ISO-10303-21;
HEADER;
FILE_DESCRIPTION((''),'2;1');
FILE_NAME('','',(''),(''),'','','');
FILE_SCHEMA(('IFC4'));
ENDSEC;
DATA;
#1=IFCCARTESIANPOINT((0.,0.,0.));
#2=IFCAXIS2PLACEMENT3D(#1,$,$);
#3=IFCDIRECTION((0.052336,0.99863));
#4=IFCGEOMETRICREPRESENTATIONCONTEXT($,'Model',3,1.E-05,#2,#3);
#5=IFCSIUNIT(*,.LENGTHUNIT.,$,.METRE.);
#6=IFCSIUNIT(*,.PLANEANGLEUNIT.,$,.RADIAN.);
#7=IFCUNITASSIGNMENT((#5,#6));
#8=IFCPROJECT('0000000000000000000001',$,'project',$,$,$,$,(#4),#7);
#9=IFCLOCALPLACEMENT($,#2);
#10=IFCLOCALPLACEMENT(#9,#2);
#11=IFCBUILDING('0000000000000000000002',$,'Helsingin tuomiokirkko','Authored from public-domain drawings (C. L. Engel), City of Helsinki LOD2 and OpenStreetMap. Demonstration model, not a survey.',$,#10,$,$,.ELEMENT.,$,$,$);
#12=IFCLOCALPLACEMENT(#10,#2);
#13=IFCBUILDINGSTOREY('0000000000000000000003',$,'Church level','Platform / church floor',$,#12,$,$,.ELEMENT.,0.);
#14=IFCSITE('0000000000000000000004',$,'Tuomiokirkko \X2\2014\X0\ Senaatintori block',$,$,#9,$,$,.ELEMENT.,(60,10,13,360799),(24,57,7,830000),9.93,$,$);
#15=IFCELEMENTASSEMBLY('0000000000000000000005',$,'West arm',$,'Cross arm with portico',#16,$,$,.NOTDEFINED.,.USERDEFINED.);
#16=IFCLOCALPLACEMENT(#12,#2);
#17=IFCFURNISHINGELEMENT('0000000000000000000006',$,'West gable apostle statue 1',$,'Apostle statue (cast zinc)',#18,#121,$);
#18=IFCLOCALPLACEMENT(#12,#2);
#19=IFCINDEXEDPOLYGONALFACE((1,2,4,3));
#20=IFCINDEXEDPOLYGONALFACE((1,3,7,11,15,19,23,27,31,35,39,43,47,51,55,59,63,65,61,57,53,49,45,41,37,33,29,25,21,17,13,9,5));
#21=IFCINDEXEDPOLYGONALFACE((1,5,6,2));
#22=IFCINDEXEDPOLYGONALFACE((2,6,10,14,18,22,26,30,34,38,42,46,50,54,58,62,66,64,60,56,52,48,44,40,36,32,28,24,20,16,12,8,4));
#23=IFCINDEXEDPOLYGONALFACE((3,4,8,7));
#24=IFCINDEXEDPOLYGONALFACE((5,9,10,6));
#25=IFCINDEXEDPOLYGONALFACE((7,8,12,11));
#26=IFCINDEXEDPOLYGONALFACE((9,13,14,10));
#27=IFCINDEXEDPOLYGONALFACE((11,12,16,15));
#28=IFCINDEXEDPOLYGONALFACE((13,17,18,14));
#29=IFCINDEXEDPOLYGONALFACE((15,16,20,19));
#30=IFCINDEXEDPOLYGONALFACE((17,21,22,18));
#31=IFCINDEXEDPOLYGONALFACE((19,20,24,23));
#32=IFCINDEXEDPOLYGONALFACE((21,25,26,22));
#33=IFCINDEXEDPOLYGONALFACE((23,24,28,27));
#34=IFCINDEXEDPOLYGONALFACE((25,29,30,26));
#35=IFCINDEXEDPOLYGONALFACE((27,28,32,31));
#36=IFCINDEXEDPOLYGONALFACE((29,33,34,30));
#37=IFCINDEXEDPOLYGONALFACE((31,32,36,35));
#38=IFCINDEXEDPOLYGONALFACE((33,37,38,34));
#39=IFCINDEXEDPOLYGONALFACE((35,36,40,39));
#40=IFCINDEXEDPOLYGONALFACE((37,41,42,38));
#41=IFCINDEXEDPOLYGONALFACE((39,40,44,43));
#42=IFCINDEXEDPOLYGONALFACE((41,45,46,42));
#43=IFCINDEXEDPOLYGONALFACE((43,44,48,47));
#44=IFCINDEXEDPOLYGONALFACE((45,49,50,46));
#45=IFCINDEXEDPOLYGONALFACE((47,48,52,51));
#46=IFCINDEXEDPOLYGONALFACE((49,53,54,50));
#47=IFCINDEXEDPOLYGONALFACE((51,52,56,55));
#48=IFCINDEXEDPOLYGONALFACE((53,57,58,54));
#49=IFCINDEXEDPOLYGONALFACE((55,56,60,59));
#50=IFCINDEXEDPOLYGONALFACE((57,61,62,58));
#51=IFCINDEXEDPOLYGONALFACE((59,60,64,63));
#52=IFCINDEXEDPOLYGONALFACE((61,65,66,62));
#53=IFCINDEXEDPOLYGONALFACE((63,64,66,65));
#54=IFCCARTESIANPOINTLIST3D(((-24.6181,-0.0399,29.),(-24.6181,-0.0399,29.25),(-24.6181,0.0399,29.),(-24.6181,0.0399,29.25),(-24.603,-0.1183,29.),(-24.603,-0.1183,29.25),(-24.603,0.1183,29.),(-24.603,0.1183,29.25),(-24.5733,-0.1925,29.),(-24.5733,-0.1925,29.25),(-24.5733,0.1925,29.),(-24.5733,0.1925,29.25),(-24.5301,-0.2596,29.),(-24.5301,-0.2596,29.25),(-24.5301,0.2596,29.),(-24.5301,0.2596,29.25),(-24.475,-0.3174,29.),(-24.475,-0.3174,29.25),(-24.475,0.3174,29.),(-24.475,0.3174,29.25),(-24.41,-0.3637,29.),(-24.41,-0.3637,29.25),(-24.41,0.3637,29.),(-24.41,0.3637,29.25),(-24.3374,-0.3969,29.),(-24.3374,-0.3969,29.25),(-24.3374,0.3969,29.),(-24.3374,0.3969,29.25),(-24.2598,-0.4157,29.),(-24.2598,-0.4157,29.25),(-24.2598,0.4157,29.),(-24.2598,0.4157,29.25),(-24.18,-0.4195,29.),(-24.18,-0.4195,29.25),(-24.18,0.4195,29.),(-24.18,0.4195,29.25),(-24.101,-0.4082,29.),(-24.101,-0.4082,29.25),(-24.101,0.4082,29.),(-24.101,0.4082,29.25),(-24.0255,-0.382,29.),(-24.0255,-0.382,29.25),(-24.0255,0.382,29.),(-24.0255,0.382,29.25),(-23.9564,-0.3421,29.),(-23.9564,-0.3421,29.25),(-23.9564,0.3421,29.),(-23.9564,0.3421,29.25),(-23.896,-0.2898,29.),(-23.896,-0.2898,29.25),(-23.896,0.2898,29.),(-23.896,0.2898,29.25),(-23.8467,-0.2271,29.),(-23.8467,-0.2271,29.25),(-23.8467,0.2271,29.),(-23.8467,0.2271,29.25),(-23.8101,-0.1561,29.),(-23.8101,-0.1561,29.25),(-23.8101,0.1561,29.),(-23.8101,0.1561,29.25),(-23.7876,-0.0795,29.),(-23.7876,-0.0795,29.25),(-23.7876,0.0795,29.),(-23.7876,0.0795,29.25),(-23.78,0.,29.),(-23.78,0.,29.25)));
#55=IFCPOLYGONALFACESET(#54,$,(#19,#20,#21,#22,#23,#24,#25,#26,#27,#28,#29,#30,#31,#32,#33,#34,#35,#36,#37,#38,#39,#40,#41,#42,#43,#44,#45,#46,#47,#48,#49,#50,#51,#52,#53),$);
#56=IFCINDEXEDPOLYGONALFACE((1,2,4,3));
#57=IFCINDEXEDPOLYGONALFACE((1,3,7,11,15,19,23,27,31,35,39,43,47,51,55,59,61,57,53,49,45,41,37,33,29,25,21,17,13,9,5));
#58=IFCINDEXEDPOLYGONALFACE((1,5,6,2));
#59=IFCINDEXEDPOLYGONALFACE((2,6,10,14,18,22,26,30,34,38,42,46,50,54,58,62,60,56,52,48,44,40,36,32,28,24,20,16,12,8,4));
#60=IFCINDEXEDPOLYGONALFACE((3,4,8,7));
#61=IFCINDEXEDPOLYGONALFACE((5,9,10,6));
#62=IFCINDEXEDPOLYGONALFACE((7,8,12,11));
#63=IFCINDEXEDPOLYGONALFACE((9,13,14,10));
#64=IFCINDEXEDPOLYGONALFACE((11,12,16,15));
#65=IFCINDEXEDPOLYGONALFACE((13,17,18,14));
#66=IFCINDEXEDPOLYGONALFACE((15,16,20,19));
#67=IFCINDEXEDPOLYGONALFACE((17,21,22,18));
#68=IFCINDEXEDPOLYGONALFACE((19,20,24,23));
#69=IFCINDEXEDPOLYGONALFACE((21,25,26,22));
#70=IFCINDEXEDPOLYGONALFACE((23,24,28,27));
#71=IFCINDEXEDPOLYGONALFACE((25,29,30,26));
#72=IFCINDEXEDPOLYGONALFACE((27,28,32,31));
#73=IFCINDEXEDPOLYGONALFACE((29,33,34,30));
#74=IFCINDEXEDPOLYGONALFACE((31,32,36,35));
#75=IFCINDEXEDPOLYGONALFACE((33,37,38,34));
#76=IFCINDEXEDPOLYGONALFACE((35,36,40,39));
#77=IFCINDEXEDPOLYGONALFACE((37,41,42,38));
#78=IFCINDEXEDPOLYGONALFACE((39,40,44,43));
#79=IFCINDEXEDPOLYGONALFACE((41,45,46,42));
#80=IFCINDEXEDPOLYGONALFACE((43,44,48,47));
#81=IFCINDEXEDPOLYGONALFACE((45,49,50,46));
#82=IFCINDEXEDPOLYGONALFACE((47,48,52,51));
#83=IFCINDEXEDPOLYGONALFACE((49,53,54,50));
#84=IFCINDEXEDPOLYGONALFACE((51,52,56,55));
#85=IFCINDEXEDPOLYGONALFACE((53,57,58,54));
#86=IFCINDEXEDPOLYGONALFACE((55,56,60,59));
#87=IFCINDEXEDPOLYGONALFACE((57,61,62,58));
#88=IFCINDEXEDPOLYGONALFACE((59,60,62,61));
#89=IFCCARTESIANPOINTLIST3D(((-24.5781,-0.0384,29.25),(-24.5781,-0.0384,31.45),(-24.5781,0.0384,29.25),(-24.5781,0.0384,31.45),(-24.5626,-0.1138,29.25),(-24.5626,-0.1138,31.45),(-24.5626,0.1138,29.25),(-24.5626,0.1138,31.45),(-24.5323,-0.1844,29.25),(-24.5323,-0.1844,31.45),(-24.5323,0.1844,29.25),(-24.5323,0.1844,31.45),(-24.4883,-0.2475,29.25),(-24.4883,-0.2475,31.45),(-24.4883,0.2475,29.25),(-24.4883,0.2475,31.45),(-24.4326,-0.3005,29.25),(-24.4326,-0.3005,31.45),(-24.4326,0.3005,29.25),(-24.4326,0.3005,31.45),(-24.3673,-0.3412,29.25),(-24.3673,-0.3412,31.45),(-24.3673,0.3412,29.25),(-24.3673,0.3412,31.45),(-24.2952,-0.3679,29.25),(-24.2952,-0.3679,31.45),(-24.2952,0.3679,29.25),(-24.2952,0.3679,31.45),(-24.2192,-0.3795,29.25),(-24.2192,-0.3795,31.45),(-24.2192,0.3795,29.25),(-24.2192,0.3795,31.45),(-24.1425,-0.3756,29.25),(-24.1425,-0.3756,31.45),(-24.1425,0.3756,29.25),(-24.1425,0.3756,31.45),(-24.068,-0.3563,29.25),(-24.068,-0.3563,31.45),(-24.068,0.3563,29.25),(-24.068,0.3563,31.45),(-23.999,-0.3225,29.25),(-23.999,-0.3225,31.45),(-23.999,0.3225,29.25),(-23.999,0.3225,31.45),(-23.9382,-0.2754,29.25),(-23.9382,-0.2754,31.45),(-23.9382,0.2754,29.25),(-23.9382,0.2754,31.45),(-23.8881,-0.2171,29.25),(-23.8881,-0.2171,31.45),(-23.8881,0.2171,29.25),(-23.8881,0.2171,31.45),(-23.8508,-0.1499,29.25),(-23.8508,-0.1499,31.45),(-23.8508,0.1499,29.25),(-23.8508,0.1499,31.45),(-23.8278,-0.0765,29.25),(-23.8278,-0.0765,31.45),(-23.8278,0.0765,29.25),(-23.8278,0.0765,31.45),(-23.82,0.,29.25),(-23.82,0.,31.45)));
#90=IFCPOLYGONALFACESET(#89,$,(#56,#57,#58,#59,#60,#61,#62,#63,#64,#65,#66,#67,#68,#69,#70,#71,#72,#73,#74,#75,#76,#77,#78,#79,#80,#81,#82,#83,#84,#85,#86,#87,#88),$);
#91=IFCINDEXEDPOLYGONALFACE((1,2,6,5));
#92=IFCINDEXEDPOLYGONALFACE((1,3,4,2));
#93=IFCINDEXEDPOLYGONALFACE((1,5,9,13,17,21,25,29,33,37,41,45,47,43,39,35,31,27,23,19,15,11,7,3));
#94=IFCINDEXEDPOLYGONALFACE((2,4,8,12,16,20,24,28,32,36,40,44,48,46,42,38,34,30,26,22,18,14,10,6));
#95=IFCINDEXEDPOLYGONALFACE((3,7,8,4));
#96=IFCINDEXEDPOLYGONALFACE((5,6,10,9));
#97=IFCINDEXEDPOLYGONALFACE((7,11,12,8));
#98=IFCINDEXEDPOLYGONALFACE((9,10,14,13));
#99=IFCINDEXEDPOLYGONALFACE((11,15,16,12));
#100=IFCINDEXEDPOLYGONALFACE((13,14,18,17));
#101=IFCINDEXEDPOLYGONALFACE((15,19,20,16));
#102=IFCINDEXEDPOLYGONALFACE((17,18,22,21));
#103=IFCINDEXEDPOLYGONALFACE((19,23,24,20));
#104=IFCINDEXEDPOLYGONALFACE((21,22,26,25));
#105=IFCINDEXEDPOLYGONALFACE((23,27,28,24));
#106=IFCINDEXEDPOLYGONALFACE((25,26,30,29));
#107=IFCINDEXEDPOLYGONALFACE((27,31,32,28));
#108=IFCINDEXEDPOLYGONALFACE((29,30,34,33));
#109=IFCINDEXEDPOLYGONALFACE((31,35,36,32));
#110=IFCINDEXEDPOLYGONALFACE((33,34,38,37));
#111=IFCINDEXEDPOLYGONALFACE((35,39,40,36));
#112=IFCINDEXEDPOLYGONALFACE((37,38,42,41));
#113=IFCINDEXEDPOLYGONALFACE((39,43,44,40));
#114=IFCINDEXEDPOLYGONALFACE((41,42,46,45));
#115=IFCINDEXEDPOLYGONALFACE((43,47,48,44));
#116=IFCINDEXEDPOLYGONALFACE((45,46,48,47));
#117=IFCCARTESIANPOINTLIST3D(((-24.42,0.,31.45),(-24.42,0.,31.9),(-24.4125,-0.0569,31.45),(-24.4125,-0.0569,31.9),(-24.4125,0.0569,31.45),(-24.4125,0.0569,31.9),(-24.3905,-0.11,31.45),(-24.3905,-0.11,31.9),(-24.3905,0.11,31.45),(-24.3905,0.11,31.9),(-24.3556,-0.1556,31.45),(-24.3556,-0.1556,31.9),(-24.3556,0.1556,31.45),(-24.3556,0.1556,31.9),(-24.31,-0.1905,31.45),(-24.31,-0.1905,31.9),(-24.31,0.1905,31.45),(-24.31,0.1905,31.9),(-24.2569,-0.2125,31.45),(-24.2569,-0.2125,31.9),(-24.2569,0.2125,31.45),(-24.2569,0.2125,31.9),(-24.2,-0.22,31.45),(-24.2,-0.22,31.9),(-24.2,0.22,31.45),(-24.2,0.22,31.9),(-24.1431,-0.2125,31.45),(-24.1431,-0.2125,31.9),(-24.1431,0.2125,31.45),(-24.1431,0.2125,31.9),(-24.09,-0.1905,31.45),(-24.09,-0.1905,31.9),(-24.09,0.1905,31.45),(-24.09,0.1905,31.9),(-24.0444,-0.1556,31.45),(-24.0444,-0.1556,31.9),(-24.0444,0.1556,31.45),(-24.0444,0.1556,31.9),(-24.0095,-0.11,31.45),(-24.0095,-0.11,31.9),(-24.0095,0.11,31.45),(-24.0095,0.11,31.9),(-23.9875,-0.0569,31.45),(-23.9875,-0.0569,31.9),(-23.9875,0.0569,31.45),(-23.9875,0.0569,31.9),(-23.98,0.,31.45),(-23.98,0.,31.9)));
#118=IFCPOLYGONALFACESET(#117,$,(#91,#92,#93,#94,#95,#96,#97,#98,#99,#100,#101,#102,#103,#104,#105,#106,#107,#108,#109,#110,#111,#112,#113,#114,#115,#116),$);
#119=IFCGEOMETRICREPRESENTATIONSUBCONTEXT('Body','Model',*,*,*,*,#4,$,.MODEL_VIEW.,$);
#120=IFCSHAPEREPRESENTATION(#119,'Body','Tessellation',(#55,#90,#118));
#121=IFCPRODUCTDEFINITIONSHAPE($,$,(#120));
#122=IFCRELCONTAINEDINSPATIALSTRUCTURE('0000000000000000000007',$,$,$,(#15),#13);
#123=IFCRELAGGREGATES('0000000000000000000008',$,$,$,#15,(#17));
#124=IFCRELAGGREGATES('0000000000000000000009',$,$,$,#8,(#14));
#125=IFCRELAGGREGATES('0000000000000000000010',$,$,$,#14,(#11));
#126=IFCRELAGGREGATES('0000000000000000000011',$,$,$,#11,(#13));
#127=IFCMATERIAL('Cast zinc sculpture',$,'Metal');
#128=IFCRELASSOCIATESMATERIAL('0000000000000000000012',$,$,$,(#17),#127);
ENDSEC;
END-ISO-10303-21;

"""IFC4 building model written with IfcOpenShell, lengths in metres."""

from ifc_helpers import new_model, si_unit, direction, frame, origin, origin_2d_with_axis, place, context, subcontext, project, spatial, circle, extrude, material, element, aggregate, save


model = new_model("IFC4")

# Units and contexts
model_context = context("Model", 3, precision=1e-05, world=origin(), true_north=direction((0.052336, 0.99863)))
body_context = subcontext(model_context, "Body", "Model", "MODEL_VIEW")
ifc_project = project(units=[si_unit("LENGTHUNIT", "METRE"), si_unit("PLANEANGLEUNIT", "RADIAN")], contexts=[model_context])

# Site, building, storey
site_placement = place(None, origin())
site = spatial("IfcSite", under=ifc_project, at=site_placement, Name="Tuomiokirkko — Senaatintori block", CompositionType="ELEMENT", RefLatitude=(60, 10, 13, 360799), RefLongitude=(24, 57, 7, 830000), RefElevation=9.93)
building_placement = place(site_placement, origin())
building = spatial("IfcBuilding", under=site, at=building_placement, Name="Helsingin tuomiokirkko", Description="Authored from public-domain drawings (C. L. Engel), City of Helsinki LOD2 and OpenStreetMap. Demonstration model, not a survey.", CompositionType="ELEMENT")
storey_placement = place(building_placement, origin())
storey = spatial("IfcBuildingStorey", under=building, at=storey_placement, Name="Church level", Description="Platform / church floor", CompositionType="ELEMENT", Elevation=0.0)

# Element assembly
assembly_1_placement = place(building_placement, origin())
assembly_1 = element("IfcElementAssembly", 1, at=assembly_1_placement, inside=storey, Name="West arm", ObjectType="Cross arm with portico", AssemblyPlace="NOTDEFINED", PredefinedType="USERDEFINED")

# Furnishing element
ifc_material_1 = material(Name="Cast zinc sculpture", Category="Metal")
furnishing_1_placement = place(building_placement, origin())
furnishing_1 = element("IfcFurnishingElement", 2, at=furnishing_1_placement, material=ifc_material_1, Name="West gable apostle statue 1", ObjectType="Apostle statue (cast zinc)", context=body_context, shape_type="SweptSolid", body=[
    extrude(circle(Radius=0.42, at=origin_2d_with_axis()), frame((-24.2, 0.0, 29.0)), (0.0, 0.0, 1.0), 0.25),
    extrude(circle(Radius=0.38, at=origin_2d_with_axis()), frame((-24.2, 0.0, 29.25)), (0.0, 0.0, 1.0), 2.2),
    extrude(circle(Radius=0.22, at=origin_2d_with_axis()), frame((-24.2, 0.0, 31.45)), (0.0, 0.0, 1.0), 0.45),
])
aggregate(assembly_1, [furnishing_1])

save(model, "model.ifc")
